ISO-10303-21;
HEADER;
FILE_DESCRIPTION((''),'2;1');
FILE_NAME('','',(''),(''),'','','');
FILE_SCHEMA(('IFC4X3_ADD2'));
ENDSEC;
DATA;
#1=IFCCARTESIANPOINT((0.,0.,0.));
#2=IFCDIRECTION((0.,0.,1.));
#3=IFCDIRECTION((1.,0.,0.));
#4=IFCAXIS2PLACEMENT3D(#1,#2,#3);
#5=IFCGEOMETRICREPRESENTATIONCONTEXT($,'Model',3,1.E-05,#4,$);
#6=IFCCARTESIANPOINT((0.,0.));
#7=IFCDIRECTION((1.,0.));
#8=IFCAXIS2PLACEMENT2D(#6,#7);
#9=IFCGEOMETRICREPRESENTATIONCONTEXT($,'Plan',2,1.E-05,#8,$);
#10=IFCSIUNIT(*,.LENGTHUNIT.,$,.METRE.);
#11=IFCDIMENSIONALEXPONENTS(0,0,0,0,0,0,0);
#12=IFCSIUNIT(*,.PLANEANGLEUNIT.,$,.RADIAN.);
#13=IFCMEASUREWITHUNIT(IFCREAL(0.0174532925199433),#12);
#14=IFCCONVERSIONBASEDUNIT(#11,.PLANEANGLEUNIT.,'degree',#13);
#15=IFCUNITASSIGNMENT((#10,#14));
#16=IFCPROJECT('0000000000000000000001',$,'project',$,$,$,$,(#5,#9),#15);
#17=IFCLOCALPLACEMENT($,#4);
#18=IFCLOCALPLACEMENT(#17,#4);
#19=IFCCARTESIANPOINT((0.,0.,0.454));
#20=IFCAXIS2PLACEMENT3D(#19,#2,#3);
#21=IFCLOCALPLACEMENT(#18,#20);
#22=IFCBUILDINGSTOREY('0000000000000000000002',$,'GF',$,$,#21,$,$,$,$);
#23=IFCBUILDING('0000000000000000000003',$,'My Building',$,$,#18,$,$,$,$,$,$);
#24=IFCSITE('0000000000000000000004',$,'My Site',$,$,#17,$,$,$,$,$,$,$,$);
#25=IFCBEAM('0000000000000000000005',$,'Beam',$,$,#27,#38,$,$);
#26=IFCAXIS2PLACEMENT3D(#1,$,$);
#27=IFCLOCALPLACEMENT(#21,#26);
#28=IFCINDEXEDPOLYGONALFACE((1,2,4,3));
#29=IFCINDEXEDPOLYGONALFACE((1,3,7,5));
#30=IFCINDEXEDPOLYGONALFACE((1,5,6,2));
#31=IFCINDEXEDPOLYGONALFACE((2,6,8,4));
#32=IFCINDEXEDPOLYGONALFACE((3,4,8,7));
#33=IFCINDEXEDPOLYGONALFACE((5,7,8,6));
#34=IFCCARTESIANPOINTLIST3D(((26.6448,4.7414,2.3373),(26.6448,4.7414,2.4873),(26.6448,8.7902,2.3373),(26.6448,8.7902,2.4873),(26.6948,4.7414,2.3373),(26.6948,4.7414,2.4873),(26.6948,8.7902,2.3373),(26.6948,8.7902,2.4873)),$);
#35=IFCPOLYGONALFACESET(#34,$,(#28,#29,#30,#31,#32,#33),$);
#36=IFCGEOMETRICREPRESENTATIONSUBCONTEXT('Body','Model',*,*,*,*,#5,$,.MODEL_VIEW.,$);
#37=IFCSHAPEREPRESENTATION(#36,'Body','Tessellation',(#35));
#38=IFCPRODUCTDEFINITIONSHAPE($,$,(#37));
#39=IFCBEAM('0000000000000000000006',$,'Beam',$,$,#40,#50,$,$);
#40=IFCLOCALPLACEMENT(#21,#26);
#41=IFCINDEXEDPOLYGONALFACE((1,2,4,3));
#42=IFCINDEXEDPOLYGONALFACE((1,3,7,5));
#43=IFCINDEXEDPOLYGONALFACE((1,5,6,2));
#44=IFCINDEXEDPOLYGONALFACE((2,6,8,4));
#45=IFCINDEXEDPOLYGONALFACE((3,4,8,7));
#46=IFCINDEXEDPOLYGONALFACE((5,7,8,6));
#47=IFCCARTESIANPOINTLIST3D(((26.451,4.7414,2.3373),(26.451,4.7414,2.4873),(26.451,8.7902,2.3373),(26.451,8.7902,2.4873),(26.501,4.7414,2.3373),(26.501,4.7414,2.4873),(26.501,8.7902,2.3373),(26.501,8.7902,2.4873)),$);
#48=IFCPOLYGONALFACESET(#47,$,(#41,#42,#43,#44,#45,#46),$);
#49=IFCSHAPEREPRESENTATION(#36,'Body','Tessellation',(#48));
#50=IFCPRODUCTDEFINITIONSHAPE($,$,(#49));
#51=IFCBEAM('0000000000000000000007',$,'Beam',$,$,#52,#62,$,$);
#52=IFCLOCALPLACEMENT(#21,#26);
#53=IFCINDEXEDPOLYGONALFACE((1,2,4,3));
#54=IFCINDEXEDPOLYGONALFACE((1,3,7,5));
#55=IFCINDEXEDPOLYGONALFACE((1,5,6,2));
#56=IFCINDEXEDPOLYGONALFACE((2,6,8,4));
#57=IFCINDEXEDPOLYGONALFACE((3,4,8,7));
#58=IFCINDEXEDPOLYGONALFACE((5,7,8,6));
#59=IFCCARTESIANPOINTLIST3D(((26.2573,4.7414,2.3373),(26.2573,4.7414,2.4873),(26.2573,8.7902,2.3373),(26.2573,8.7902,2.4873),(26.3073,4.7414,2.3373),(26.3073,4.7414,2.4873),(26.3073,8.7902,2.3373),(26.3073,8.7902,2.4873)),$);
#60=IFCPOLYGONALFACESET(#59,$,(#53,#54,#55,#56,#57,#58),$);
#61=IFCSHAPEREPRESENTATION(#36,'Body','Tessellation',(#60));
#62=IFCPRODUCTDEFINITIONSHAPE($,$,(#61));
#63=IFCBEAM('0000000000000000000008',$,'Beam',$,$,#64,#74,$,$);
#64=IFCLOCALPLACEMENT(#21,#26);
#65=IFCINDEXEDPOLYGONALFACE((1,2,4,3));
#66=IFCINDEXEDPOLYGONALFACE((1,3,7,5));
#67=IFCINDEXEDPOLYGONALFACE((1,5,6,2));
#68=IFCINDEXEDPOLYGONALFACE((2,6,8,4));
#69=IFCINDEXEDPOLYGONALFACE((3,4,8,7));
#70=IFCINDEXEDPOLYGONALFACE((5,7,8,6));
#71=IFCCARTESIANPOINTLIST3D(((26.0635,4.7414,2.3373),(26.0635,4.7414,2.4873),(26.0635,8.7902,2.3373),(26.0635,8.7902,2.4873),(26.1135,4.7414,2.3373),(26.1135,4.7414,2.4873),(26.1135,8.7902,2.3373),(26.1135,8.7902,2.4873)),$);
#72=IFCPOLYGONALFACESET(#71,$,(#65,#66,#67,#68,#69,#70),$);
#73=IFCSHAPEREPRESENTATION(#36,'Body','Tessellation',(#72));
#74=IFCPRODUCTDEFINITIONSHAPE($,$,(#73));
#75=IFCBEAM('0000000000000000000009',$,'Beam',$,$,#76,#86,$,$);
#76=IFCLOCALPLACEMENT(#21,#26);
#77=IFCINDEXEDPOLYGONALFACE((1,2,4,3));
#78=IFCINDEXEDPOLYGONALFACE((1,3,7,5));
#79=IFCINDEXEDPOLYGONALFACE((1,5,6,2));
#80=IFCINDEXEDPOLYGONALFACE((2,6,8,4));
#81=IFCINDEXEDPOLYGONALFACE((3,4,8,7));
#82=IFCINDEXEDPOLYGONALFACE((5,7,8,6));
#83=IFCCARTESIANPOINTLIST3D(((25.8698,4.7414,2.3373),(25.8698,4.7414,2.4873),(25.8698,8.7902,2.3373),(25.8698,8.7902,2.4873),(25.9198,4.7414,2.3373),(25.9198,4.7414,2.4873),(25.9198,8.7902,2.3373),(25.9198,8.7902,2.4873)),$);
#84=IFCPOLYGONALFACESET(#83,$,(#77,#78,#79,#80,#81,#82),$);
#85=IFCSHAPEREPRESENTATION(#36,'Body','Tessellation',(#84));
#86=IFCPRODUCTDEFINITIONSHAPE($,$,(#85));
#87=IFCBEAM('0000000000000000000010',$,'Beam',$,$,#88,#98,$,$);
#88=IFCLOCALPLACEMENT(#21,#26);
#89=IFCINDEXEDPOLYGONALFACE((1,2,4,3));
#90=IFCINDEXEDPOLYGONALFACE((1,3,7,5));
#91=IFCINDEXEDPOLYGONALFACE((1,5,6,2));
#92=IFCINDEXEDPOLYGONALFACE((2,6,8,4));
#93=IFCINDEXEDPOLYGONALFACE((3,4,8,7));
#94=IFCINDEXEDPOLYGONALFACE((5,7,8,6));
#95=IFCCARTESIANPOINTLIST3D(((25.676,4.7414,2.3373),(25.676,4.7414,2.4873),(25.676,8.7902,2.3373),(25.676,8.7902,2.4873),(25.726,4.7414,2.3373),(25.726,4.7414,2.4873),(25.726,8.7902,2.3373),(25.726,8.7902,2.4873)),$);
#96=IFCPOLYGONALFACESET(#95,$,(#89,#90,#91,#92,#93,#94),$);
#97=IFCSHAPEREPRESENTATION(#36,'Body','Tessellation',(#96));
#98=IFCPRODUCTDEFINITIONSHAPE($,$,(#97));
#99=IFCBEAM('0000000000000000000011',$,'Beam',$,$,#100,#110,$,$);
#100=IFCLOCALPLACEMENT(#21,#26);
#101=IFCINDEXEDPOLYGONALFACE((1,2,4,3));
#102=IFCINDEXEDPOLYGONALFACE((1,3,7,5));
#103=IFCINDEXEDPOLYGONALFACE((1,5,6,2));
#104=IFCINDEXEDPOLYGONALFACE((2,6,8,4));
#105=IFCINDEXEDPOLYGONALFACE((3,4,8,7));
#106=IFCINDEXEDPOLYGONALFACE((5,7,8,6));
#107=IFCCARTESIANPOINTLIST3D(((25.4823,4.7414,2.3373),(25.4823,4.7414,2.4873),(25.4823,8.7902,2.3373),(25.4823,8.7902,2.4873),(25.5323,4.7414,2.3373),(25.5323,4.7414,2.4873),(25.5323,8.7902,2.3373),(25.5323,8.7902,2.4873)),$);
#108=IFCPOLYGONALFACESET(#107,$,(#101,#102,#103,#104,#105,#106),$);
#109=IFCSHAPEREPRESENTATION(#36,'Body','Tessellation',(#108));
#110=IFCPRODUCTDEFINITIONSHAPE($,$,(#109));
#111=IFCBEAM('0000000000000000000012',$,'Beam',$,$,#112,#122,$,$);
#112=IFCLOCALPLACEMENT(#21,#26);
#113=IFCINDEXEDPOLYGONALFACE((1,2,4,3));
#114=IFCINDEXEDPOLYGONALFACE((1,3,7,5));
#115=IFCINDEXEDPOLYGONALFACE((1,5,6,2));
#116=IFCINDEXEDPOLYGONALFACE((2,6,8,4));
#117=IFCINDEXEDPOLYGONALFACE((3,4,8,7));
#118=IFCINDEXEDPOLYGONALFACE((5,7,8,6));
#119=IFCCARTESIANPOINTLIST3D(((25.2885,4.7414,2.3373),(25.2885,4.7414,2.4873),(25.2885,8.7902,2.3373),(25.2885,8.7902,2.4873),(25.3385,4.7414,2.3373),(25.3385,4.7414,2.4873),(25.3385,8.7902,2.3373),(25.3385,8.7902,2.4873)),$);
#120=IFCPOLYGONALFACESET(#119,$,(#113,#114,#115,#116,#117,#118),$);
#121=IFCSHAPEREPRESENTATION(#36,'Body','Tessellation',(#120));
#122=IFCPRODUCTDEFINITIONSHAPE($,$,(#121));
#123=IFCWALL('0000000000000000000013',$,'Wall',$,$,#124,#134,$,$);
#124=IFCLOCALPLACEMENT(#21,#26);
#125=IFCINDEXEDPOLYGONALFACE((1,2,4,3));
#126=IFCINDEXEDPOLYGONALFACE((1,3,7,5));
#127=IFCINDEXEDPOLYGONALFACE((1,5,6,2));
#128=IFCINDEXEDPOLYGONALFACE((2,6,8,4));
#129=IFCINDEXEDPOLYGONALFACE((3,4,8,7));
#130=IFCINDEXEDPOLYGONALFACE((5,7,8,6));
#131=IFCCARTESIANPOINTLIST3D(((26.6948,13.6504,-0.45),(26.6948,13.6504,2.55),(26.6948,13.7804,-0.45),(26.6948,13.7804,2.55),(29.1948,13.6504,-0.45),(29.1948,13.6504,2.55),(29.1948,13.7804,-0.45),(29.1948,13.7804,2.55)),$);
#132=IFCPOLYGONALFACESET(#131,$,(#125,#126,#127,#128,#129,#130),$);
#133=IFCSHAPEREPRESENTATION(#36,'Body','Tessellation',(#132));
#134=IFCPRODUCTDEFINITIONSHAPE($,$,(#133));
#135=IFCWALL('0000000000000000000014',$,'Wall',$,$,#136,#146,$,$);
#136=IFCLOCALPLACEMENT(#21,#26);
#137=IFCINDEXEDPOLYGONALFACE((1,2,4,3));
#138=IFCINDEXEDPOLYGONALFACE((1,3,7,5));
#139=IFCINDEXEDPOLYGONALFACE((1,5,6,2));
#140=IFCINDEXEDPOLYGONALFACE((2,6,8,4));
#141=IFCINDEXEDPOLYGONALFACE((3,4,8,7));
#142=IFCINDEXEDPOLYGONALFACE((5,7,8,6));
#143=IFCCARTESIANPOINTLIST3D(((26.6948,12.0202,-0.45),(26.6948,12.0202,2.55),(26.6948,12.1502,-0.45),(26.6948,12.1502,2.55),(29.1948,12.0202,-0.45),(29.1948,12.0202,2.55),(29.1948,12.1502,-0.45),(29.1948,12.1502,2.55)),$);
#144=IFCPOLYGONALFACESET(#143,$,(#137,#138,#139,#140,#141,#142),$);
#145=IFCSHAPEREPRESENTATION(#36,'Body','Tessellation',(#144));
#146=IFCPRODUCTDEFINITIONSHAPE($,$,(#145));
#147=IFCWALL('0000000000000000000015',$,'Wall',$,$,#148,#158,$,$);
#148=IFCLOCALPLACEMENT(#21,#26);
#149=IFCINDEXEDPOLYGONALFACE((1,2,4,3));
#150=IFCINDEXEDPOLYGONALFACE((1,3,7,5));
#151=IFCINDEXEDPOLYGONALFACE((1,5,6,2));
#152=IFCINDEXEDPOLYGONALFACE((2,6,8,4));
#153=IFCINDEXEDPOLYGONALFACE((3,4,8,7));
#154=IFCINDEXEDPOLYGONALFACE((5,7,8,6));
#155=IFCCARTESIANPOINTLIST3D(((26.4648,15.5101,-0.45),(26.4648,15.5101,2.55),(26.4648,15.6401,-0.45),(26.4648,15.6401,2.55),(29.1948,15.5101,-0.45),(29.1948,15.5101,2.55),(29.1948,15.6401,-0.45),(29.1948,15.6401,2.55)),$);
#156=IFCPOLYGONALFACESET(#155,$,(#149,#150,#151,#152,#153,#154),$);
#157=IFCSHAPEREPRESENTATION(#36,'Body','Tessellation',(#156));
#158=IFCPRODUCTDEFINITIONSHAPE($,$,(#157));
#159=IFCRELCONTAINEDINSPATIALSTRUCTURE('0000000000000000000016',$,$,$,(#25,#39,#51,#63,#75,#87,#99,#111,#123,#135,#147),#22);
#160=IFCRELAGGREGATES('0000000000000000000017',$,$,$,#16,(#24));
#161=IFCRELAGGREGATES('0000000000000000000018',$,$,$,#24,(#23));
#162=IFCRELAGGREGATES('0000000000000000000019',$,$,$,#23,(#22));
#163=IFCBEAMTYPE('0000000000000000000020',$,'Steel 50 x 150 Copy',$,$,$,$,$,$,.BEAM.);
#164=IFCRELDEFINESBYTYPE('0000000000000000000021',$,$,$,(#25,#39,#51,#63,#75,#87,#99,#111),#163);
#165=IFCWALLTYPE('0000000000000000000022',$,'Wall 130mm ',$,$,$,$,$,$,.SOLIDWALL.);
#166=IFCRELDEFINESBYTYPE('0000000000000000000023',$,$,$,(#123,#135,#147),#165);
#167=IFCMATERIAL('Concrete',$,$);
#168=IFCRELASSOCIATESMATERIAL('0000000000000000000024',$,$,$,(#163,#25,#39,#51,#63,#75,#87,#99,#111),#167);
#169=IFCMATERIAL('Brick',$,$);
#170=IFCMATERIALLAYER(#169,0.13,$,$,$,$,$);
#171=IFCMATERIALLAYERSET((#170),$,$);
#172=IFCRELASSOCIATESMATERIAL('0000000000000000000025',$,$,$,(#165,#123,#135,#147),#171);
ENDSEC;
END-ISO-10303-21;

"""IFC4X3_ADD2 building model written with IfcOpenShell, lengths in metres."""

from ifc_helpers import new_model, entity, si_unit, converted_unit, frame, origin_with_axes, origin_2d_with_axis, place, context, subcontext, project, spatial, indexed_curve, rectangle, outline, extrude, material, layer, layer_set, layer_usage, material_profile, profile_set, profile_usage, type_object, element, save


model = new_model("IFC4X3_ADD2")

# Units and contexts
model_context = context("Model", 3, precision=1e-05, world=origin_with_axes())
plan_context = context("Plan", 2, precision=1e-05, world=origin_2d_with_axis())
body_context_1 = subcontext(model_context, "Body", "Model", "MODEL_VIEW")
ifc_project = project(units=[si_unit("LENGTHUNIT", "METRE"), converted_unit("PLANEANGLEUNIT", "degree", entity("IfcReal", 0.0174532925199433), si_unit("PLANEANGLEUNIT", "RADIAN"), dimensions=[0, 0, 0, 0, 0, 0, 0])], contexts=[model_context, plan_context])

# Site, building, storey
site_placement = place(None, origin_with_axes())
site = spatial("IfcSite", under=ifc_project, at=site_placement, Name="My Site")
building_placement = place(site_placement, origin_with_axes())
building = spatial("IfcBuilding", under=site, at=building_placement, Name="My Building")
storey_placement = place(building_placement, frame((0.0, 0.0, 0.454), z_axis=(0.0, 0.0, 1.0), x_axis=(1.0, 0.0, 0.0)))
storey = spatial("IfcBuildingStorey", under=building, at=storey_placement, Name="GF")

# Beams
ifc_material_1 = material(Name="Concrete")
ifc_material_profile = material_profile(ifc_material_1, rectangle(XDim=0.05, YDim=0.15))
ifc_profile_set = profile_set([ifc_material_profile])
ifc_profile_usage_1 = profile_usage(ifc_profile_set)
beam_type = type_object("IfcBeamType", Name="Steel 50 x 150 Copy", PredefinedType="BEAM", material=ifc_profile_set)
beam_1_placement = place(storey_placement, frame((26.6698, 8.7902, 2.4123), z_axis=(0.0, -1.0, 0.0), x_axis=(1.0, 0.0, 0.0)))
element("IfcBeam", 1, at=beam_1_placement, inside=storey, type_object=beam_type, material=ifc_profile_usage_1, Name="Beam", context=body_context_1, shape_type="SweptSolid", body=[
    extrude(rectangle(XDim=0.05, YDim=0.15), origin_with_axes(), (0.0, 0.0, 1.0), 4.0488),
])
ifc_profile_usage_2 = profile_usage(ifc_profile_set)
beam_2_placement = place(storey_placement, frame((26.476, 8.7902, 2.4123), z_axis=(0.0, -1.0, 0.0), x_axis=(1.0, 0.0, 0.0)))
element("IfcBeam", 2, at=beam_2_placement, inside=storey, type_object=beam_type, material=ifc_profile_usage_2, Name="Beam", context=body_context_1, shape_type="SweptSolid", body=[
    extrude(rectangle(XDim=0.05, YDim=0.15), origin_with_axes(), (0.0, 0.0, 1.0), 4.0488),
])
ifc_profile_usage_3 = profile_usage(ifc_profile_set)
beam_3_placement = place(storey_placement, frame((26.2823, 8.7902, 2.4123), z_axis=(0.0, -1.0, 0.0), x_axis=(1.0, 0.0, 0.0)))
element("IfcBeam", 3, at=beam_3_placement, inside=storey, type_object=beam_type, material=ifc_profile_usage_3, Name="Beam", context=body_context_1, shape_type="SweptSolid", body=[
    extrude(rectangle(XDim=0.05, YDim=0.15), origin_with_axes(), (0.0, 0.0, 1.0), 4.0488),
])
ifc_profile_usage_4 = profile_usage(ifc_profile_set)
beam_4_placement = place(storey_placement, frame((26.0885, 8.7902, 2.4123), z_axis=(0.0, -1.0, 0.0), x_axis=(1.0, 0.0, 0.0)))
element("IfcBeam", 4, at=beam_4_placement, inside=storey, type_object=beam_type, material=ifc_profile_usage_4, Name="Beam", context=body_context_1, shape_type="SweptSolid", body=[
    extrude(rectangle(XDim=0.05, YDim=0.15), origin_with_axes(), (0.0, 0.0, 1.0), 4.0488),
])
ifc_profile_usage_5 = profile_usage(ifc_profile_set)
beam_5_placement = place(storey_placement, frame((25.8948, 8.7902, 2.4123), z_axis=(0.0, -1.0, 0.0), x_axis=(1.0, 0.0, 0.0)))
element("IfcBeam", 5, at=beam_5_placement, inside=storey, type_object=beam_type, material=ifc_profile_usage_5, Name="Beam", context=body_context_1, shape_type="SweptSolid", body=[
    extrude(rectangle(XDim=0.05, YDim=0.15), origin_with_axes(), (0.0, 0.0, 1.0), 4.0488),
])
ifc_profile_usage_6 = profile_usage(ifc_profile_set)
beam_6_placement = place(storey_placement, frame((25.701, 8.7902, 2.4123), z_axis=(0.0, -1.0, 0.0), x_axis=(1.0, 0.0, 0.0)))
element("IfcBeam", 6, at=beam_6_placement, inside=storey, type_object=beam_type, material=ifc_profile_usage_6, Name="Beam", context=body_context_1, shape_type="SweptSolid", body=[
    extrude(rectangle(XDim=0.05, YDim=0.15), origin_with_axes(), (0.0, 0.0, 1.0), 4.0488),
])
ifc_profile_usage_7 = profile_usage(ifc_profile_set)
beam_7_placement = place(storey_placement, frame((25.5073, 8.7902, 2.4123), z_axis=(0.0, -1.0, 0.0), x_axis=(1.0, 0.0, 0.0)))
element("IfcBeam", 7, at=beam_7_placement, inside=storey, type_object=beam_type, material=ifc_profile_usage_7, Name="Beam", context=body_context_1, shape_type="SweptSolid", body=[
    extrude(rectangle(XDim=0.05, YDim=0.15), origin_with_axes(), (0.0, 0.0, 1.0), 4.0488),
])
ifc_profile_usage_8 = profile_usage(ifc_profile_set)
beam_8_placement = place(storey_placement, frame((25.3135, 8.7902, 2.4123), z_axis=(0.0, -1.0, 0.0), x_axis=(1.0, 0.0, 0.0)))
element("IfcBeam", 8, at=beam_8_placement, inside=storey, type_object=beam_type, material=ifc_profile_usage_8, Name="Beam", context=body_context_1, shape_type="SweptSolid", body=[
    extrude(rectangle(XDim=0.05, YDim=0.15), origin_with_axes(), (0.0, 0.0, 1.0), 4.0488),
])

# Walls
ifc_material_2 = material(Name="Brick")
ifc_layer_1 = layer(ifc_material_2, 0.13)
ifc_layer_set_1 = layer_set([ifc_layer_1])
ifc_layer_usage_1 = layer_usage(ifc_layer_set_1, "AXIS2", "POSITIVE", 0.0)
wall_type_1 = type_object("IfcWallType", Name="Wall 130mm ", PredefinedType="SOLIDWALL", material=ifc_layer_set_1)
wall_1_placement = place(storey_placement, frame((29.1948, 13.7804, -0.45), z_axis=(0.0, 0.0, 1.0), x_axis=(-1.0, 0.0, 0.0)))
element("IfcWall", 9, at=wall_1_placement, inside=storey, type_object=wall_type_1, material=ifc_layer_usage_1, Name="Wall", context=body_context_1, shape_type="SweptSolid", body=[
    extrude(outline(indexed_curve([(0.0, 0.0), (0.0, 0.13), (2.5, 0.13), (2.5, 0.0), (0.0, 0.0)], self_intersect=False)), origin_with_axes(), (0.0, 0.0, 1.0), 3.0),
])
ifc_layer_usage_2 = layer_usage(ifc_layer_set_1, "AXIS2", "POSITIVE", 0.0)
wall_2_placement = place(storey_placement, frame((29.1948, 12.1502, -0.45), z_axis=(0.0, 0.0, 1.0), x_axis=(-1.0, 0.0, 0.0)))
element("IfcWall", 10, at=wall_2_placement, inside=storey, type_object=wall_type_1, material=ifc_layer_usage_2, Name="Wall", context=body_context_1, shape_type="SweptSolid", body=[
    extrude(outline(indexed_curve([(0.0, 0.0), (0.0, 0.13), (2.5, 0.13), (2.5, 0.0), (0.0, 0.0)], self_intersect=False)), origin_with_axes(), (0.0, 0.0, 1.0), 3.0),
])
ifc_layer_usage_3 = layer_usage(ifc_layer_set_1, "AXIS2", "POSITIVE", 0.0)
wall_3_placement = place(storey_placement, frame((29.1948, 15.6401, -0.45), z_axis=(0.0, 0.0, 1.0), x_axis=(-1.0, 0.0, 0.0)))
element("IfcWall", 11, at=wall_3_placement, inside=storey, type_object=wall_type_1, material=ifc_layer_usage_3, Name="Wall", context=body_context_1, shape_type="SweptSolid", body=[
    extrude(outline(indexed_curve([(0.0, 0.0), (0.0, 0.13), (2.73, 0.13), (2.73, 0.0), (0.0, 0.0)], self_intersect=False)), origin_with_axes(), (0.0, 0.0, 1.0), 3.0),
])

save(model, "model.ifc")
